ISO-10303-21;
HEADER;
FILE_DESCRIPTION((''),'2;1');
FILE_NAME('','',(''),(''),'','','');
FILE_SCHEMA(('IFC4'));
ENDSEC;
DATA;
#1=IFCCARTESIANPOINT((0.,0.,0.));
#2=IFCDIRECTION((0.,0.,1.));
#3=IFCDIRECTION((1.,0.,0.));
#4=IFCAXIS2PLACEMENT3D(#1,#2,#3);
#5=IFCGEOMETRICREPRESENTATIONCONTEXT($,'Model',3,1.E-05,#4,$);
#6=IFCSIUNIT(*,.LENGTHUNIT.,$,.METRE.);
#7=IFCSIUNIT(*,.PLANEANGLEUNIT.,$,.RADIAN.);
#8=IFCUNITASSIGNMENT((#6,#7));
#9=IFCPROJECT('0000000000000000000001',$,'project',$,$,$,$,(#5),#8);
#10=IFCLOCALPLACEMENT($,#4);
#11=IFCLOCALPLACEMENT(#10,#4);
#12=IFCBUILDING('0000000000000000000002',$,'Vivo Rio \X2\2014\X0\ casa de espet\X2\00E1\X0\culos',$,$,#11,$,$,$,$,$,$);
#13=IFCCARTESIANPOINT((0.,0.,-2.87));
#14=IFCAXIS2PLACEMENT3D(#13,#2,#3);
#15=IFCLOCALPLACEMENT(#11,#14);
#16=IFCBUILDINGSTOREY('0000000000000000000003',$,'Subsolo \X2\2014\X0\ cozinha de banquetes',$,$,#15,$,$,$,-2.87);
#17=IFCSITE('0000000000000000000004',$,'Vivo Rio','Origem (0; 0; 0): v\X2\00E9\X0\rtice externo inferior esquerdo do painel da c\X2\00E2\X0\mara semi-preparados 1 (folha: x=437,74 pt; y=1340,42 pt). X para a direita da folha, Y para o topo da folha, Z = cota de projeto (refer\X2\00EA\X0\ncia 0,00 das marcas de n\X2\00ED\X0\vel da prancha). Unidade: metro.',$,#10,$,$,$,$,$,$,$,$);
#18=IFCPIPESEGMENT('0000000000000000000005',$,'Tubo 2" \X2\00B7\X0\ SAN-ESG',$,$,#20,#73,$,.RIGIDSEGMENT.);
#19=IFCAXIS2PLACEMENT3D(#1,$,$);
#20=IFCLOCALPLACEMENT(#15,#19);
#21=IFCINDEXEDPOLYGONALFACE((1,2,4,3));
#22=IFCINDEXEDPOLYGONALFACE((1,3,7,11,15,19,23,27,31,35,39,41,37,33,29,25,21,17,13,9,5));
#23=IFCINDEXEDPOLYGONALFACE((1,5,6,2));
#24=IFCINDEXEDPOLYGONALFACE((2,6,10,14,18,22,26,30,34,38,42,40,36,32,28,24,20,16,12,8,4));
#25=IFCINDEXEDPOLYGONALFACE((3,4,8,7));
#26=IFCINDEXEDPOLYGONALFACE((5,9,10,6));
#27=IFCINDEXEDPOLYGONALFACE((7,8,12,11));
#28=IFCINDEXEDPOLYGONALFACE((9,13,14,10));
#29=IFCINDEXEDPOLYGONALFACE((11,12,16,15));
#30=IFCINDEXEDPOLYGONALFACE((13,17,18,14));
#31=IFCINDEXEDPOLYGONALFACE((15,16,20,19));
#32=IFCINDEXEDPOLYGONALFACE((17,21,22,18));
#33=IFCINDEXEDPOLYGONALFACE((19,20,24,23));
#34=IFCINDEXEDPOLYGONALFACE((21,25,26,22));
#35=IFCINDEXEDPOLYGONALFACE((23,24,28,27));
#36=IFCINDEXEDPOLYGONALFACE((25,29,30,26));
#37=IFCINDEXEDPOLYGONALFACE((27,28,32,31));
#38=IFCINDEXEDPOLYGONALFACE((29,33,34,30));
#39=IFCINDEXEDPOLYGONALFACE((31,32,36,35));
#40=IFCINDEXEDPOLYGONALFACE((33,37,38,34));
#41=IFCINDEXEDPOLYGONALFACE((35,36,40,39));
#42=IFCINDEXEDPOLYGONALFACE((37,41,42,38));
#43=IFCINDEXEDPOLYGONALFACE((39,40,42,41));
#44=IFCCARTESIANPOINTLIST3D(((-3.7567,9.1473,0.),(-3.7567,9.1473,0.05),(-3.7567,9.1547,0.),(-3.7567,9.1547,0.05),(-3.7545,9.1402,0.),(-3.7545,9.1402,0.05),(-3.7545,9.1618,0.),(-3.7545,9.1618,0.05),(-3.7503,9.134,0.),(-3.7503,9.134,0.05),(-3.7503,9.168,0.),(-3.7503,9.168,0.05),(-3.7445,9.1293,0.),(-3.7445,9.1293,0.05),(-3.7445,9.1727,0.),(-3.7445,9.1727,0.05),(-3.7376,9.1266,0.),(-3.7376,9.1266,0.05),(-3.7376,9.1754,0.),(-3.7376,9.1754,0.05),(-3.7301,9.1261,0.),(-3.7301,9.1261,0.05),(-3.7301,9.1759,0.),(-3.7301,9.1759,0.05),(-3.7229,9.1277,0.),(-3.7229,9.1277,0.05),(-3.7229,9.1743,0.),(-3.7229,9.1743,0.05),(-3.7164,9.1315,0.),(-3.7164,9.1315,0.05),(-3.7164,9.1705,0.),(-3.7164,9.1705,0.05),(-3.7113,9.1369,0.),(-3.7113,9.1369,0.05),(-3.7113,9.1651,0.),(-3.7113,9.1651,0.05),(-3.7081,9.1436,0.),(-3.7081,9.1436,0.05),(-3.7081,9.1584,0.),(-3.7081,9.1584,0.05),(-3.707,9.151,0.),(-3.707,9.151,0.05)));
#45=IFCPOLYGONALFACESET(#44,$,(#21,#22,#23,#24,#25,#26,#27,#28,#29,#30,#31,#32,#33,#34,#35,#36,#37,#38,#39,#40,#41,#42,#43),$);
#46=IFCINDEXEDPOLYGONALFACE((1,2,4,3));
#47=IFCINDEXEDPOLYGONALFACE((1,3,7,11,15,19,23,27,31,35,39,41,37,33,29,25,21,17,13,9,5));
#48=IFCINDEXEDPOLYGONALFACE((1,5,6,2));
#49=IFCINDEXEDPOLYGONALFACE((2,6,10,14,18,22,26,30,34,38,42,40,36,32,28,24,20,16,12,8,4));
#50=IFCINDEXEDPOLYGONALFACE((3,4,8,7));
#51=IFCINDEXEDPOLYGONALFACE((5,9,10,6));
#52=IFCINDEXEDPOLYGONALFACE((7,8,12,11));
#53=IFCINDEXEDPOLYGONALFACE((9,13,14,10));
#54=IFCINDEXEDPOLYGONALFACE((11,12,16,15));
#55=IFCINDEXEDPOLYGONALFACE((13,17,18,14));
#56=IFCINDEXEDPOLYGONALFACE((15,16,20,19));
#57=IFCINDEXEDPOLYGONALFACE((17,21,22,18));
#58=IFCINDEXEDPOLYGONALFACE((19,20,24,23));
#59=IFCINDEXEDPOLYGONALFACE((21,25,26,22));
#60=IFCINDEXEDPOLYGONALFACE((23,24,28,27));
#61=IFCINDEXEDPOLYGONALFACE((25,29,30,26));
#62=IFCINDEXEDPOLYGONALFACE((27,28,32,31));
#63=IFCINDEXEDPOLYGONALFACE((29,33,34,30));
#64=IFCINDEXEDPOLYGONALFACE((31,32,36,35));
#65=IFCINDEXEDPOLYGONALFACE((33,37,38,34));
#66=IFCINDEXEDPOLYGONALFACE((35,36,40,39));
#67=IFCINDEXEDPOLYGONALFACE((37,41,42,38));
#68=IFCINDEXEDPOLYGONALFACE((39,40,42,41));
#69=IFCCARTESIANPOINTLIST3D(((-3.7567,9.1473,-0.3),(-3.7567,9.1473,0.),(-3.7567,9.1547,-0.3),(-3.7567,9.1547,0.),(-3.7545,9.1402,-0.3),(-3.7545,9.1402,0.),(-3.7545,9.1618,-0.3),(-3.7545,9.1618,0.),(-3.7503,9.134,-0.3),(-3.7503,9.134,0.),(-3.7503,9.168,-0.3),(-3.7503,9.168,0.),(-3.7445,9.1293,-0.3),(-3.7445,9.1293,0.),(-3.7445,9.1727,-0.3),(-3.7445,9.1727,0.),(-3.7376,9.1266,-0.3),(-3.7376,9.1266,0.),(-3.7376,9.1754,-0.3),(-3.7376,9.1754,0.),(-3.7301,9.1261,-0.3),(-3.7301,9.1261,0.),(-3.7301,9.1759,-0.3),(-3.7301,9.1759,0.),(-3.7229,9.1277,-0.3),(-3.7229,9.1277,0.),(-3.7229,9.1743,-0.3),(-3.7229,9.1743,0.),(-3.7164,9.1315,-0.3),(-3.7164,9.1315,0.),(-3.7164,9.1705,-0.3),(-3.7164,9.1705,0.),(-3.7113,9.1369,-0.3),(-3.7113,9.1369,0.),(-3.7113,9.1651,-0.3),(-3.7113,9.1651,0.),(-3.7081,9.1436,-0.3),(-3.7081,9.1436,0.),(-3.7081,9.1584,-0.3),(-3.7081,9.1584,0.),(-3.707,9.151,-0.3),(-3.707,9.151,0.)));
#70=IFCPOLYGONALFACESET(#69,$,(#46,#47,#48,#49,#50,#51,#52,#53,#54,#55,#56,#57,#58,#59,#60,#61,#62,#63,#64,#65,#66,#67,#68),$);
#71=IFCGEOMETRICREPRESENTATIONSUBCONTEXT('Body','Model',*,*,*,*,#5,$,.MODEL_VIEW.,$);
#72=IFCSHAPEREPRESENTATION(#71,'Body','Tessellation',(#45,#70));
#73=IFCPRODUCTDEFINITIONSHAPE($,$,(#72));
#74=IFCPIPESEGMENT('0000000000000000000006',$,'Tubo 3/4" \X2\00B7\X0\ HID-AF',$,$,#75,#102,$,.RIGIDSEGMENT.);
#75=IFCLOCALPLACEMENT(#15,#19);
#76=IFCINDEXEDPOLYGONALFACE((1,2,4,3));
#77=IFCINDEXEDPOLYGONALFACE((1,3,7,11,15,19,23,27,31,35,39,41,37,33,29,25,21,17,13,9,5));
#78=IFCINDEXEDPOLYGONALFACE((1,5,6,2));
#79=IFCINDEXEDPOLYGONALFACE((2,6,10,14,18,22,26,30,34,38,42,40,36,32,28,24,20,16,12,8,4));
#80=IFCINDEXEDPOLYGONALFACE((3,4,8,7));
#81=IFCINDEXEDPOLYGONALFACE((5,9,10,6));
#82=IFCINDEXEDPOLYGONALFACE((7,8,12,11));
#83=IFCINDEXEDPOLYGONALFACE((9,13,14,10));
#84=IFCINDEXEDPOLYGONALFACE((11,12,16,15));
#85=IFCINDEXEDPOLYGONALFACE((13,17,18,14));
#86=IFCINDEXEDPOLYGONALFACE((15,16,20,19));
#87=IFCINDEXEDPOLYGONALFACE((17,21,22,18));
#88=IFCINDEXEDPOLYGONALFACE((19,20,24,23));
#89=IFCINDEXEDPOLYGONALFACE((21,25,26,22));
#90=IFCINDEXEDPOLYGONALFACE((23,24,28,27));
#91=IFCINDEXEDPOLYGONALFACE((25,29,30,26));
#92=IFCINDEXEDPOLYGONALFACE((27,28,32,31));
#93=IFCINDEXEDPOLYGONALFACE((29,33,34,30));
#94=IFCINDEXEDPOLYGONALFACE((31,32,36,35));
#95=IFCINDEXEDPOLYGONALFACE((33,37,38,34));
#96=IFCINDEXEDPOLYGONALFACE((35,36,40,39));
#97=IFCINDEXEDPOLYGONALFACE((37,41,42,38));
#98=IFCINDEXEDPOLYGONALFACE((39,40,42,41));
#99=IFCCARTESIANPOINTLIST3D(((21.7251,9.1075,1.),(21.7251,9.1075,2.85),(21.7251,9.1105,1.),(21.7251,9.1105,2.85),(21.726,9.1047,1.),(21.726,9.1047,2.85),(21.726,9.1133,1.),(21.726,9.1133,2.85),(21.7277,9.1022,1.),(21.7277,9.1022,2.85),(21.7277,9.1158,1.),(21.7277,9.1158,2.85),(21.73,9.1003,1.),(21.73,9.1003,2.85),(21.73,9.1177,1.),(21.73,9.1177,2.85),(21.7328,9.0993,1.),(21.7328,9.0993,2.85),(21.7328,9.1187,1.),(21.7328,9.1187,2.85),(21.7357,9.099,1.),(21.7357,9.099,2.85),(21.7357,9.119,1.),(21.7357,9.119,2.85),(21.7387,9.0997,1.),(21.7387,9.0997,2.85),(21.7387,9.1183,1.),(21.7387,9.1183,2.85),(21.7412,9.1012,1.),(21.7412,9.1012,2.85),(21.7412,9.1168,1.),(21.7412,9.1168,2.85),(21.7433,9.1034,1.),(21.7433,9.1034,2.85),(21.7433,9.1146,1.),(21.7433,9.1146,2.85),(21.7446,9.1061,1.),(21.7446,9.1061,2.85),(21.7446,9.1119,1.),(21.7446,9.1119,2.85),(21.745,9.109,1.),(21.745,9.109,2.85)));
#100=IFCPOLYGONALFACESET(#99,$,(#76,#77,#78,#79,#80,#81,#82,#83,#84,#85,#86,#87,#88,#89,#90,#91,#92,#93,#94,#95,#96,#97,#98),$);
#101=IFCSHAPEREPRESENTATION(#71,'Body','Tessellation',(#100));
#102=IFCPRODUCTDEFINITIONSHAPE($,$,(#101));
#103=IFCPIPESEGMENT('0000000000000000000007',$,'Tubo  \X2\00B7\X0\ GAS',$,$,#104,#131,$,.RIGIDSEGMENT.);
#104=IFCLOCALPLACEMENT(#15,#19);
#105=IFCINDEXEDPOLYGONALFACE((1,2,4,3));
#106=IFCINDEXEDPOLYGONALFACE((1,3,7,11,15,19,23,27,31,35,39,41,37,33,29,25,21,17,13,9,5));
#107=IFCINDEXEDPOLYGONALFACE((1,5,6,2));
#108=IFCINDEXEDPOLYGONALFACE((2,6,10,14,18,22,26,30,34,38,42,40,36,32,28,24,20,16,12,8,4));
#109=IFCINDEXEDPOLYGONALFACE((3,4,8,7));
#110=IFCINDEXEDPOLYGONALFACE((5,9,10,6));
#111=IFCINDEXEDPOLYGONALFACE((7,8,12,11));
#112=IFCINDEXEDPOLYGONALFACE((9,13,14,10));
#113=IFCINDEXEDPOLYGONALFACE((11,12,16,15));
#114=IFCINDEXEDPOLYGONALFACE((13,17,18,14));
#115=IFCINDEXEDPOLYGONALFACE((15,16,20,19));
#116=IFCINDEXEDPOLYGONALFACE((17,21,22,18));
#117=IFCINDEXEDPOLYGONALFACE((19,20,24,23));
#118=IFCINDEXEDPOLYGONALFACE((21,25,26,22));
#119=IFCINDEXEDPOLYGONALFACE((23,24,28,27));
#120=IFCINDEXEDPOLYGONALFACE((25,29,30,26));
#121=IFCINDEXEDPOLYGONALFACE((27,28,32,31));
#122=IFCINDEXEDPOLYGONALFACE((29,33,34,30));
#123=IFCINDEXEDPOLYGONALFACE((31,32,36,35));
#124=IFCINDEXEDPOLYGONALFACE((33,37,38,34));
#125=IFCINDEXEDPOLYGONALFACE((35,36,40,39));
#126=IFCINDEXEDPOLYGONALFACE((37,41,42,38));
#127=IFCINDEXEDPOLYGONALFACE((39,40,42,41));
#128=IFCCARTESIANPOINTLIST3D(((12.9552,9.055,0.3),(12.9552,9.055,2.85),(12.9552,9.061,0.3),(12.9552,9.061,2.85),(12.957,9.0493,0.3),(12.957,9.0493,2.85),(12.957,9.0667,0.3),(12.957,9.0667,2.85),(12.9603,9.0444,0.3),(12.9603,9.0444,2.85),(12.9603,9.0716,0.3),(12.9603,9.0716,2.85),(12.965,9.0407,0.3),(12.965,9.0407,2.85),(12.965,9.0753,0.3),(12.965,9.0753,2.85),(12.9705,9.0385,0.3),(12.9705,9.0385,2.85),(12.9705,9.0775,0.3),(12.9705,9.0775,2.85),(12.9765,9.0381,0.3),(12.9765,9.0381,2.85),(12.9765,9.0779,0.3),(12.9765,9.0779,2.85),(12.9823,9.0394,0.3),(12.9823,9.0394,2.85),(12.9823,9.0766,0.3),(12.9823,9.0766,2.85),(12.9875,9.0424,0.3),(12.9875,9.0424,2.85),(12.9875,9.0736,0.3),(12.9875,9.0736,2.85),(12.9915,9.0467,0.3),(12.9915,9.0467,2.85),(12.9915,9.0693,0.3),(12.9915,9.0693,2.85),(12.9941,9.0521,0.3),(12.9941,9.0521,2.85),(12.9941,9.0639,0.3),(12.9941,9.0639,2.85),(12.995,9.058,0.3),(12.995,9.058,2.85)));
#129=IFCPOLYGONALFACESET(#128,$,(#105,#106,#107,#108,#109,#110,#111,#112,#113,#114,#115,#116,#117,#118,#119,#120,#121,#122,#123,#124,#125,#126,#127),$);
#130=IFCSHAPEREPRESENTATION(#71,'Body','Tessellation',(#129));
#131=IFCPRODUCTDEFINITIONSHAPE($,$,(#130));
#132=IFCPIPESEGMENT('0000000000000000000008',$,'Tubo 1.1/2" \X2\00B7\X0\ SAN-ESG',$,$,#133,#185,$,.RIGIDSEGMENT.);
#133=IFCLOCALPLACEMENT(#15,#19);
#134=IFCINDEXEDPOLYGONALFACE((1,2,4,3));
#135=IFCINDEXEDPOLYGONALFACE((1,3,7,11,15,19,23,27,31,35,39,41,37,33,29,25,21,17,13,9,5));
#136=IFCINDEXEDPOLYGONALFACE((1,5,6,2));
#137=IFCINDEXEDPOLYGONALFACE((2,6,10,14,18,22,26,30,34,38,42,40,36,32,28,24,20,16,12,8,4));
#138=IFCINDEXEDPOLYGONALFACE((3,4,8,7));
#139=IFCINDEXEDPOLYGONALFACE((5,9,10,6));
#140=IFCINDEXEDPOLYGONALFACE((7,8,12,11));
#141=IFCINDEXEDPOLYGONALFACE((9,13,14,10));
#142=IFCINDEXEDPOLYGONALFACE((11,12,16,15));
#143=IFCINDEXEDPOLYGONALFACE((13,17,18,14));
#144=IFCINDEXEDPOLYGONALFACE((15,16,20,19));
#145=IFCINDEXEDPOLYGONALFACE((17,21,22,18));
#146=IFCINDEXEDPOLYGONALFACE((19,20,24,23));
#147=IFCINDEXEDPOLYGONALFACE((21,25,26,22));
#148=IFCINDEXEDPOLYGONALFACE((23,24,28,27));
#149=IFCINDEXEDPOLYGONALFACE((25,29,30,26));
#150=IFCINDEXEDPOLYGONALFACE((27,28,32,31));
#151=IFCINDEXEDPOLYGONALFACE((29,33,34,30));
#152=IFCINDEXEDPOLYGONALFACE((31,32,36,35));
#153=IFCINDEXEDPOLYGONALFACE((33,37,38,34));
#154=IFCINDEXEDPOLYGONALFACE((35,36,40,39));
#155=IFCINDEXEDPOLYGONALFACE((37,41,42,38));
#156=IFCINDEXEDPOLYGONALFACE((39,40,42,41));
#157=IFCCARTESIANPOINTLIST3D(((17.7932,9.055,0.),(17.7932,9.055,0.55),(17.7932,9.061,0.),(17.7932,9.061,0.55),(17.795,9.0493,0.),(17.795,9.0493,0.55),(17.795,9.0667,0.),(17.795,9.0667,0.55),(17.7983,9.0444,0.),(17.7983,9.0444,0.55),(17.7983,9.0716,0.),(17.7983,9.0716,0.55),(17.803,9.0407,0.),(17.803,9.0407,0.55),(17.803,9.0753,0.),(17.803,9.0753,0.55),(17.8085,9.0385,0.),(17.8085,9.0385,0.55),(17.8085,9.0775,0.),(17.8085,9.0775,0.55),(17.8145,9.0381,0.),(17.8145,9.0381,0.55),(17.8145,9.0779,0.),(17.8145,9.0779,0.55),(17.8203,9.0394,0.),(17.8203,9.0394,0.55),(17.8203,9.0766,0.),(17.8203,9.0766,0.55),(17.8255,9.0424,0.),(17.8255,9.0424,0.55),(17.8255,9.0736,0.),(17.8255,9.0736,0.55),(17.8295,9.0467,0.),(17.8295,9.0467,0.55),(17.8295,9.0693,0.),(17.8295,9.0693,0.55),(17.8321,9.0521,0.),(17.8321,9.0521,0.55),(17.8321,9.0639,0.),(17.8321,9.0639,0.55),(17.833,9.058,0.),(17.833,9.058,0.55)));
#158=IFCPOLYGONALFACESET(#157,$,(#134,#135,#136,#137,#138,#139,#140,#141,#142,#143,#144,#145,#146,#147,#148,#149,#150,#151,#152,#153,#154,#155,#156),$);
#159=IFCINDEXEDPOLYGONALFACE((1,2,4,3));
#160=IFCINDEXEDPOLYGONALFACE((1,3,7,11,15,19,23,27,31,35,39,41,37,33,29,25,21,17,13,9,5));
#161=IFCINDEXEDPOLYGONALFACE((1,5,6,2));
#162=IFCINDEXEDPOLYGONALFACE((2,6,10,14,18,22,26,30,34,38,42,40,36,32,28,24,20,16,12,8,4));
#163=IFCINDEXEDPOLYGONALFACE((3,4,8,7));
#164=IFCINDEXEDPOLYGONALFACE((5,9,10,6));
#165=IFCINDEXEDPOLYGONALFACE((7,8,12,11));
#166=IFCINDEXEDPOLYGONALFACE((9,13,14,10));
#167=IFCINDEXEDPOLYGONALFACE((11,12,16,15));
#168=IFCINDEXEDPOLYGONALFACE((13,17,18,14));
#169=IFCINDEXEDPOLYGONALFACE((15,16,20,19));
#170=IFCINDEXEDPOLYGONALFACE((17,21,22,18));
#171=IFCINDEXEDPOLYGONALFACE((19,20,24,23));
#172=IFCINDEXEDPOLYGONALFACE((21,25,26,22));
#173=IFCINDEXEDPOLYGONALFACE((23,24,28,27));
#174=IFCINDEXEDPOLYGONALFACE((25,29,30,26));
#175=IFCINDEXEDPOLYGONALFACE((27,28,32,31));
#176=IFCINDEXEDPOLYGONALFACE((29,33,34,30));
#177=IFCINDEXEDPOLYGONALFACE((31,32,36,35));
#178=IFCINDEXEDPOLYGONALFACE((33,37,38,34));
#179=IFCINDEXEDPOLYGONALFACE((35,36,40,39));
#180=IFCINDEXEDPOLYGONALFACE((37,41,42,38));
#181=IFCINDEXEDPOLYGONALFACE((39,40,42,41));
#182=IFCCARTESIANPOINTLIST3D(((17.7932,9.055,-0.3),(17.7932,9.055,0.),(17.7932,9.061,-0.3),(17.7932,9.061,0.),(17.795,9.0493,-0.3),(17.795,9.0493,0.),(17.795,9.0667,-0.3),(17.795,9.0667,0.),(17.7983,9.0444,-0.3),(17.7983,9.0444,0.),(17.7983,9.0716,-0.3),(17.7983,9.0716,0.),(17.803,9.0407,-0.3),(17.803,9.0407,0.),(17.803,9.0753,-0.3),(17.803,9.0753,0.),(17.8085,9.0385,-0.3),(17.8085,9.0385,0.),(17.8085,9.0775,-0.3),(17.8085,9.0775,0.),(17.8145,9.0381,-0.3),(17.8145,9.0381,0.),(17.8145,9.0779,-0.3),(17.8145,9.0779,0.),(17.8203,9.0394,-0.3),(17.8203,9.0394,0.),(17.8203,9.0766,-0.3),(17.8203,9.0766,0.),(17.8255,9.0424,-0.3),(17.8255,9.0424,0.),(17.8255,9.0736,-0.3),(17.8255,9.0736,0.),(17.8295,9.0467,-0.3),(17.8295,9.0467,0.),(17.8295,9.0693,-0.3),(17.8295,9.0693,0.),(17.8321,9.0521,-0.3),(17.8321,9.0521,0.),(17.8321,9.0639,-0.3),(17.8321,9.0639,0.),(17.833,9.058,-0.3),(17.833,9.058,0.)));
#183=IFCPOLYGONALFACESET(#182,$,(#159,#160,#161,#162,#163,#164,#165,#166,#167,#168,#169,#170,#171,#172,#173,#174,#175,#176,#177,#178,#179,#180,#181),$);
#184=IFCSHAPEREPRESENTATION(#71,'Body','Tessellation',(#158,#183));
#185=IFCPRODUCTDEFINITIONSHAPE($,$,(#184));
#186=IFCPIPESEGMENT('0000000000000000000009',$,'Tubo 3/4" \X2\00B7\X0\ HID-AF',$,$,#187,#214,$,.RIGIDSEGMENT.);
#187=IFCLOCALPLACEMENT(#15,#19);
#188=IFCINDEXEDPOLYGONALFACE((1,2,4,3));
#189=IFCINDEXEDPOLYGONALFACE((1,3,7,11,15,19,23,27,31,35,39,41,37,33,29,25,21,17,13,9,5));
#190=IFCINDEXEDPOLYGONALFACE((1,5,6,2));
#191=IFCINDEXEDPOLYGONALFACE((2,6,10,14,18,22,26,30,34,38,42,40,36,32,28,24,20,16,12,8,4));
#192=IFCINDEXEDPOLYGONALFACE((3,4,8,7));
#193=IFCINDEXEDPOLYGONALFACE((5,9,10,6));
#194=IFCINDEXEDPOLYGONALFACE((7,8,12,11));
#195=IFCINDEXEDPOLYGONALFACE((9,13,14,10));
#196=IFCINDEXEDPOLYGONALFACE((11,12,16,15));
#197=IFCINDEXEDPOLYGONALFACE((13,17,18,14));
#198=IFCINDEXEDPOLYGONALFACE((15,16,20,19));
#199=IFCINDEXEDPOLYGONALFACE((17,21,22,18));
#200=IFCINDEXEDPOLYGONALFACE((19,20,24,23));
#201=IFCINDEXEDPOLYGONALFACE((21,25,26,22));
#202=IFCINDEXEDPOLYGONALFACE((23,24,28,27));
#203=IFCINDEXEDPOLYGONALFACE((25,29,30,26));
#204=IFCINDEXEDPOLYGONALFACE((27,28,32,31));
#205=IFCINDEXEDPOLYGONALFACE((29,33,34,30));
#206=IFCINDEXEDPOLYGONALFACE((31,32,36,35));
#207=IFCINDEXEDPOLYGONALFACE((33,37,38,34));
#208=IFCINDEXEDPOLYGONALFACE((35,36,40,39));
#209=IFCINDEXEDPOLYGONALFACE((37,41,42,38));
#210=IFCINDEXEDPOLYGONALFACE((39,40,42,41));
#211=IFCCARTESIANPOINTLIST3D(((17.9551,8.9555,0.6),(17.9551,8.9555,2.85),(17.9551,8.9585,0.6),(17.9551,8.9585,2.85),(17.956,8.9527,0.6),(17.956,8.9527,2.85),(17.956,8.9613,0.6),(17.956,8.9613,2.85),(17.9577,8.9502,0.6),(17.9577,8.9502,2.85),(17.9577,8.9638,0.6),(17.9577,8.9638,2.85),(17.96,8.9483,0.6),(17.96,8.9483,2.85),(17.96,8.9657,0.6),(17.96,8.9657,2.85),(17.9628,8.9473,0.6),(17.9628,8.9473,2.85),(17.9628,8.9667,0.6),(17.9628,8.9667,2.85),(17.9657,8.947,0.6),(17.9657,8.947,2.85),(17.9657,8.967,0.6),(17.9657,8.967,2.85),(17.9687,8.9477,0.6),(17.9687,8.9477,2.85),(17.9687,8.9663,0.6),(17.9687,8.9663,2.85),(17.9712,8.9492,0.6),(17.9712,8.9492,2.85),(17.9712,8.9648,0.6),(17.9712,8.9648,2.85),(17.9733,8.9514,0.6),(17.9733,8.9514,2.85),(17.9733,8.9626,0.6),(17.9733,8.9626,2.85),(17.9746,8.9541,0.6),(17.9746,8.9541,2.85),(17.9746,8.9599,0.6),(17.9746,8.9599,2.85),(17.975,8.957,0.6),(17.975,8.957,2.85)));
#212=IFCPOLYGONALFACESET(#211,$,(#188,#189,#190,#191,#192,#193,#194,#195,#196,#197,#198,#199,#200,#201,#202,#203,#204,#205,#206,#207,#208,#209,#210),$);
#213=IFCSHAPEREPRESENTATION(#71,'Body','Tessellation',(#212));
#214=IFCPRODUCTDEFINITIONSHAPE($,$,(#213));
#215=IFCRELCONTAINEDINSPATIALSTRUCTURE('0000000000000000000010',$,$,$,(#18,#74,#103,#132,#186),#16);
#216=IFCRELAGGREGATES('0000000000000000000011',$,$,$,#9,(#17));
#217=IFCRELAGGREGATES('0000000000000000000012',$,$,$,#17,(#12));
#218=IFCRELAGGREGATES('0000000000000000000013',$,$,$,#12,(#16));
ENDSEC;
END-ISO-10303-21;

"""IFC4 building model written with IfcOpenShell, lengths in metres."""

from ifc_helpers import new_model, si_unit, frame, origin_with_axes, origin_2d, place, context, subcontext, project, spatial, circle, extrude, element, save


model = new_model("IFC4")

# Units and contexts
model_context = context("Model", 3, precision=1e-05, world=origin_with_axes())
body_context = subcontext(model_context, "Body", "Model", "MODEL_VIEW")
ifc_project = project(units=[si_unit("LENGTHUNIT", "METRE"), si_unit("PLANEANGLEUNIT", "RADIAN")], contexts=[model_context])

# Site, building, storey
site_placement = place(None, origin_with_axes())
site = spatial("IfcSite", under=ifc_project, at=site_placement, Name="Vivo Rio", Description="Origem (0; 0; 0): vértice externo inferior esquerdo do painel da câmara semi-preparados 1 (folha: x=437,74 pt; y=1340,42 pt). X para a direita da folha, Y para o topo da folha, Z = cota de projeto (referência 0,00 das marcas de nível da prancha). Unidade: metro.")
building_placement = place(site_placement, origin_with_axes())
building = spatial("IfcBuilding", under=site, at=building_placement, Name="Vivo Rio — casa de espetáculos")
storey_placement = place(building_placement, frame((0.0, 0.0, -2.87), z_axis=(0.0, 0.0, 1.0), x_axis=(1.0, 0.0, 0.0)))
storey = spatial("IfcBuildingStorey", under=building, at=storey_placement, Name="Subsolo — cozinha de banquetes", Elevation=-2.87)

# Pipe segments
pipe_segment_1_placement = place(storey_placement, origin_with_axes())
element("IfcPipeSegment", 1, at=pipe_segment_1_placement, inside=storey, Name="Tubo 2\" · SAN-ESG", PredefinedType="RIGIDSEGMENT", context=body_context, shape_type="SweptSolid", body=[
    extrude(circle(Radius=0.025, at=origin_2d()), frame((-3.732, 9.151, 0.05), z_axis=(0.0, 0.0, -1.0), x_axis=(1.0, 0.0, 0.0)), (0.0, 0.0, 1.0), 0.05),
    extrude(circle(Radius=0.025, at=origin_2d()), frame((-3.732, 9.151, 0.0), z_axis=(0.0, 0.0, -1.0), x_axis=(1.0, 0.0, 0.0)), (0.0, 0.0, 1.0), 0.3),
])
pipe_segment_2_placement = place(storey_placement, origin_with_axes())
element("IfcPipeSegment", 2, at=pipe_segment_2_placement, inside=storey, Name="Tubo 3/4\" · HID-AF", PredefinedType="RIGIDSEGMENT", context=body_context, shape_type="SweptSolid", body=[
    extrude(circle(Radius=0.01, at=origin_2d()), frame((21.735, 9.109, 2.85), z_axis=(0.0, 0.0, -1.0), x_axis=(1.0, 0.0, 0.0)), (0.0, 0.0, 1.0), 1.85),
])
pipe_segment_3_placement = place(storey_placement, origin_with_axes())
element("IfcPipeSegment", 3, at=pipe_segment_3_placement, inside=storey, Name="Tubo  · GAS", PredefinedType="RIGIDSEGMENT", context=body_context, shape_type="SweptSolid", body=[
    extrude(circle(Radius=0.02, at=origin_2d()), frame((12.975, 9.058, 2.85), z_axis=(0.0, 0.0, -1.0), x_axis=(1.0, 0.0, 0.0)), (0.0, 0.0, 1.0), 2.55),
])
pipe_segment_4_placement = place(storey_placement, origin_with_axes())
element("IfcPipeSegment", 4, at=pipe_segment_4_placement, inside=storey, Name="Tubo 1.1/2\" · SAN-ESG", PredefinedType="RIGIDSEGMENT", context=body_context, shape_type="SweptSolid", body=[
    extrude(circle(Radius=0.02, at=origin_2d()), frame((17.813, 9.058, 0.55), z_axis=(0.0, 0.0, -1.0), x_axis=(1.0, 0.0, 0.0)), (0.0, 0.0, 1.0), 0.55),
    extrude(circle(Radius=0.02, at=origin_2d()), frame((17.813, 9.058, 0.0), z_axis=(0.0, 0.0, -1.0), x_axis=(1.0, 0.0, 0.0)), (0.0, 0.0, 1.0), 0.3),
])
pipe_segment_5_placement = place(storey_placement, origin_with_axes())
element("IfcPipeSegment", 5, at=pipe_segment_5_placement, inside=storey, Name="Tubo 3/4\" · HID-AF", PredefinedType="RIGIDSEGMENT", context=body_context, shape_type="SweptSolid", body=[
    extrude(circle(Radius=0.01, at=origin_2d()), frame((17.965, 8.957, 2.85), z_axis=(0.0, 0.0, -1.0), x_axis=(1.0, 0.0, 0.0)), (0.0, 0.0, 1.0), 2.25),
])

save(model, "model.ifc")
